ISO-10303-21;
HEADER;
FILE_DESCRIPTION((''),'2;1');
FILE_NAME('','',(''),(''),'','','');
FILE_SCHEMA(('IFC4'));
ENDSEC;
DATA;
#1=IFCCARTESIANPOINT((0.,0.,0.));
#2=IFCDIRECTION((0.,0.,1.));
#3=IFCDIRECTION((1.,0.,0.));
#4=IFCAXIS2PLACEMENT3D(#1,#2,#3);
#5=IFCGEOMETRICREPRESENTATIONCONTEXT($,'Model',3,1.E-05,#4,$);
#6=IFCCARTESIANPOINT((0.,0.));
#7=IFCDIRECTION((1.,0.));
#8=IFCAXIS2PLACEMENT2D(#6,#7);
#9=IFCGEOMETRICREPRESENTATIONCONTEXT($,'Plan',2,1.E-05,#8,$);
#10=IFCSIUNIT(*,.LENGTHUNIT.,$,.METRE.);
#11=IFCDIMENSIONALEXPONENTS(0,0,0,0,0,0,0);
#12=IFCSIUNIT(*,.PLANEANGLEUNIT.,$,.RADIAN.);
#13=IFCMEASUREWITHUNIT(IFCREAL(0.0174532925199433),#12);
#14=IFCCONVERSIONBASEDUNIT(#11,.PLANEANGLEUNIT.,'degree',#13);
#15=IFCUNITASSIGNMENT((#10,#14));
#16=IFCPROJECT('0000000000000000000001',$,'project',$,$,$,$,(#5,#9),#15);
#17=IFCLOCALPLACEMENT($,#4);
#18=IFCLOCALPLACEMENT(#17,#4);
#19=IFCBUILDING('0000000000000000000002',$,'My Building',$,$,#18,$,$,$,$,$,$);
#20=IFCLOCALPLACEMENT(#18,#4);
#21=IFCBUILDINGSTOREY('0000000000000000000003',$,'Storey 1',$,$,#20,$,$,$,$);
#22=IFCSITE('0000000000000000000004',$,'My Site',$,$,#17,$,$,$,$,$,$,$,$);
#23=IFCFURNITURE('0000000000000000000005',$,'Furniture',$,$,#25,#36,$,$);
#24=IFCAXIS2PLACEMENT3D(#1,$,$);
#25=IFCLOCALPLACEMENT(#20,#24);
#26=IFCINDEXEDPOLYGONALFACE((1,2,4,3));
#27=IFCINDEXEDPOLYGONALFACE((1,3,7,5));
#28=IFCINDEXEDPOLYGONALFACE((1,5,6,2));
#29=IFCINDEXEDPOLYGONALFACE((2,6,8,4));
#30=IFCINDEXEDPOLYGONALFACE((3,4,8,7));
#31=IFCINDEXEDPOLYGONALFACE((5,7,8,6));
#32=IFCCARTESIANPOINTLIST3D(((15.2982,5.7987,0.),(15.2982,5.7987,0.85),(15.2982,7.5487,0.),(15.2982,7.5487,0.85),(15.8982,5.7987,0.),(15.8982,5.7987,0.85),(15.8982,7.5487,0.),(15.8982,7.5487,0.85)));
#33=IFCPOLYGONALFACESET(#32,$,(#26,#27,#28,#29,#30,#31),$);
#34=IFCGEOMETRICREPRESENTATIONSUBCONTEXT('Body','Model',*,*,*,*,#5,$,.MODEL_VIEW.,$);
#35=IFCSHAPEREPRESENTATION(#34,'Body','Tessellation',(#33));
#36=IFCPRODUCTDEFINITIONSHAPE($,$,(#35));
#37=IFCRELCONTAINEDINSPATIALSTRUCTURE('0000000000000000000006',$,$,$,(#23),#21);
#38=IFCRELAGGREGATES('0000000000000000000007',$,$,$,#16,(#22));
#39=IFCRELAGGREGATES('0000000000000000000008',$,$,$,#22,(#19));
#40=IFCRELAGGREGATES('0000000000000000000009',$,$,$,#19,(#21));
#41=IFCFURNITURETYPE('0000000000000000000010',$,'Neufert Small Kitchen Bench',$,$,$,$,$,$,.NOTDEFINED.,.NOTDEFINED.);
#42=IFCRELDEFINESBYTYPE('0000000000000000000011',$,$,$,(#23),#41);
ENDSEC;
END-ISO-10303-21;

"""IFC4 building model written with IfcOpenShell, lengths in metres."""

from ifc_helpers import new_model, entity, si_unit, converted_unit, frame, origin_with_axes, origin_2d_with_axis, place, context, subcontext, project, spatial, line, indexed_curve, outline, extrude, shape, source, transform, mapped, type_object, type_shapes, element, save


model = new_model("IFC4")

# Units and contexts
model_context = context("Model", 3, precision=1e-05, world=origin_with_axes())
plan_context = context("Plan", 2, precision=1e-05, world=origin_2d_with_axis())
body_context_1 = subcontext(model_context, "Body", "Model", "MODEL_VIEW")
body_context_2 = subcontext(plan_context, "Body", "Plan", "PLAN_VIEW")
ifc_project = project(units=[si_unit("LENGTHUNIT", "METRE"), converted_unit("PLANEANGLEUNIT", "degree", entity("IfcReal", 0.0174532925199433), si_unit("PLANEANGLEUNIT", "RADIAN"), dimensions=[0, 0, 0, 0, 0, 0, 0])], contexts=[model_context, plan_context])

# Site, building, storey
site_placement = place(None, origin_with_axes())
site = spatial("IfcSite", under=ifc_project, at=site_placement, Name="My Site")
building_placement = place(site_placement, origin_with_axes())
building = spatial("IfcBuilding", under=site, at=building_placement, Name="My Building")
storey_placement = place(building_placement, origin_with_axes())
storey = spatial("IfcBuildingStorey", under=building, at=storey_placement, Name="Storey 1")

# Furniture
furniture_type_1 = type_object("IfcFurnitureType", Name="Neufert Small Kitchen Bench", AssemblyPlace="NOTDEFINED", PredefinedType="NOTDEFINED")
shared_shape_1 = source(origin_with_axes(), body_context_1, "Body", "SweptSolid", [
    extrude(outline(indexed_curve([(0.0, 0.0), (1.75, 0.0), (1.75, 0.6), (0.0, 0.6)], segments=[line(1, 2, 3, 4, 1)])), origin_with_axes(), (0.0, 0.0, 1.0), 0.85),
])
shared_shape_2 = source(origin_with_axes(), body_context_2, "Body", "Curve2D", [
    entity("IfcIndexedPolyCurve", entity("IfcCartesianPointList2D", [[0.0, 0.0], [1.75, 0.0], [1.75, 0.6], [0.0, 0.6]]), [entity("IfcLineIndex", [1, 2, 3, 4, 1])]),
])
type_shapes(furniture_type_1, [shared_shape_1, shared_shape_2])
furniture_1_placement = place(storey_placement, frame((15.2982, 7.5487, 0.0), z_axis=(0.0, 0.0, 1.0), x_axis=(0.0, -1.0, 0.0)))
element("IfcFurniture", 1, at=furniture_1_placement, inside=storey, type_object=furniture_type_1, Name="Furniture", shapes=[
    shape(body_context_1, "Body", "MappedRepresentation", [mapped(shared_shape_1, transform((0.0, 0.0, 0.0), x_axis=(1.0, 0.0, 0.0), y_axis=(0.0, 1.0, 0.0), z_axis=(0.0, 0.0, 1.0), scale=1.0))]),
    shape(body_context_2, "Body", "MappedRepresentation", [mapped(shared_shape_2, transform((0.0, 0.0, 0.0), x_axis=(1.0, 0.0, 0.0), y_axis=(0.0, 1.0, 0.0), z_axis=(0.0, 0.0, 1.0), scale=1.0))]),
])

save(model, "model.ifc")
